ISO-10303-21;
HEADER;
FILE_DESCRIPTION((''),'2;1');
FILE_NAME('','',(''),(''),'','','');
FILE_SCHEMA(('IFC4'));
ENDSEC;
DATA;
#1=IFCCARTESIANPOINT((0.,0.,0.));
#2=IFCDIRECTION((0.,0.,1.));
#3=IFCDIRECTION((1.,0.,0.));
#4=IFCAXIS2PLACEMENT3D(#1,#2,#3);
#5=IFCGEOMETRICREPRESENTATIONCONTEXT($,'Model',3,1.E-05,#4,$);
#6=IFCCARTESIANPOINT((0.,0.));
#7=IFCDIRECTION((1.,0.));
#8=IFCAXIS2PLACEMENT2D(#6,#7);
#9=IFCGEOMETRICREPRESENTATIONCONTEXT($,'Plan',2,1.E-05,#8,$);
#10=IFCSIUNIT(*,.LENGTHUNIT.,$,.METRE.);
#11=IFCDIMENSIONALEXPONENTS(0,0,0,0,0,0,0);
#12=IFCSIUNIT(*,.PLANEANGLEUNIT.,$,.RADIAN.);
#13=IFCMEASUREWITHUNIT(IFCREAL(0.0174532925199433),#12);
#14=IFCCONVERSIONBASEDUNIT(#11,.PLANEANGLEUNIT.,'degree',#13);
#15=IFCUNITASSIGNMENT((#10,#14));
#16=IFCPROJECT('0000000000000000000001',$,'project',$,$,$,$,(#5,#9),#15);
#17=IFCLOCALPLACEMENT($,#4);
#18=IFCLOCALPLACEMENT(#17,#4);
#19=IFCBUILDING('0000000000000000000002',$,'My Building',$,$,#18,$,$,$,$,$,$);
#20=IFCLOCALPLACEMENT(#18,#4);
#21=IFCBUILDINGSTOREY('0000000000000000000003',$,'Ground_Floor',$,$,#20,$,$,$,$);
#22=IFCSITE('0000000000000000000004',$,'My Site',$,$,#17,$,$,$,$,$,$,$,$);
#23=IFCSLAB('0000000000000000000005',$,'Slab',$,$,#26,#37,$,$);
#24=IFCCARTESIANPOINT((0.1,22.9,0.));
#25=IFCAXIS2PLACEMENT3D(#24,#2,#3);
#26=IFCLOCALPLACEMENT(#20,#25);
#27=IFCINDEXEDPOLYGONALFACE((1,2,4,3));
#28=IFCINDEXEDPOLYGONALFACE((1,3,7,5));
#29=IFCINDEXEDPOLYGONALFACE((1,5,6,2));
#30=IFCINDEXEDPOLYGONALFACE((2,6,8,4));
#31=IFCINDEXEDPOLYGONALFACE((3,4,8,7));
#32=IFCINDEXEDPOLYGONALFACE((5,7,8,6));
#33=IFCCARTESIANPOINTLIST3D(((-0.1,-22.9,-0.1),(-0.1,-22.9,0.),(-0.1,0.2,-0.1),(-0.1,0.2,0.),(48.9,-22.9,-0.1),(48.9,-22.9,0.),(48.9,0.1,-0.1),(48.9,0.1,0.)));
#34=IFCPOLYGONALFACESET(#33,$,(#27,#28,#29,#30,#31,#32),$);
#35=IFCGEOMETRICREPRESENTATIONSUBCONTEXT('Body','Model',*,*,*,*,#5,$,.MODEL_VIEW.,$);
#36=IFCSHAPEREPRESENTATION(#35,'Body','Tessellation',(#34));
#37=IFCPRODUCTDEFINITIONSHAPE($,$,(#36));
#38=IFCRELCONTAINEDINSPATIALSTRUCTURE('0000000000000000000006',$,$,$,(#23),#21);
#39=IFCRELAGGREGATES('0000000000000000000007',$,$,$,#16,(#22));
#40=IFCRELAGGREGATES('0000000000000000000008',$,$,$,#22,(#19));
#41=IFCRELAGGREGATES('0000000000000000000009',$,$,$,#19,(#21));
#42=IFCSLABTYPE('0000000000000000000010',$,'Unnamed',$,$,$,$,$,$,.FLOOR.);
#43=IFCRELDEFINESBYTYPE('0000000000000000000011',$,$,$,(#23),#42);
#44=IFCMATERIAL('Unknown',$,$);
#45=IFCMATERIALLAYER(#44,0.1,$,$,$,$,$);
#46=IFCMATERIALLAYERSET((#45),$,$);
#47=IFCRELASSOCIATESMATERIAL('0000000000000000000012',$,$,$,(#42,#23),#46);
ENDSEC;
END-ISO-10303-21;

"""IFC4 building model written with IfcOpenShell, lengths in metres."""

from ifc_helpers import new_model, entity, si_unit, converted_unit, frame, origin_with_axes, origin_2d_with_axis, place, context, subcontext, project, spatial, indexed_curve, outline, extrude, material, layer, layer_set, layer_usage, type_object, element, save


model = new_model("IFC4")

# Units and contexts
model_context = context("Model", 3, precision=1e-05, world=origin_with_axes())
plan_context = context("Plan", 2, precision=1e-05, world=origin_2d_with_axis())
body_context_1 = subcontext(model_context, "Body", "Model", "MODEL_VIEW")
ifc_project = project(units=[si_unit("LENGTHUNIT", "METRE"), converted_unit("PLANEANGLEUNIT", "degree", entity("IfcReal", 0.0174532925199433), si_unit("PLANEANGLEUNIT", "RADIAN"), dimensions=[0, 0, 0, 0, 0, 0, 0])], contexts=[model_context, plan_context])

# Site, building, storey
site_placement = place(None, origin_with_axes())
site = spatial("IfcSite", under=ifc_project, at=site_placement, Name="My Site")
building_placement = place(site_placement, origin_with_axes())
building = spatial("IfcBuilding", under=site, at=building_placement, Name="My Building")
storey_placement = place(building_placement, origin_with_axes())
storey = spatial("IfcBuildingStorey", under=building, at=storey_placement, Name="Ground_Floor")

# Slab
ifc_material = material(Name="Unknown")
ifc_layer_1 = layer(ifc_material, 0.1)
ifc_layer_set_1 = layer_set([ifc_layer_1])
ifc_layer_usage_1 = layer_usage(ifc_layer_set_1, "AXIS3", "POSITIVE", -0.1)
slab_type = type_object("IfcSlabType", Name="Unnamed", PredefinedType="FLOOR", material=ifc_layer_set_1)
slab_placement = place(storey_placement, frame((0.1, 22.9, 0.0), z_axis=(0.0, 0.0, 1.0), x_axis=(1.0, 0.0, 0.0)))
element("IfcSlab", 1, at=slab_placement, inside=storey, type_object=slab_type, material=ifc_layer_usage_1, Name="Slab", context=body_context_1, shape_type="SweptSolid", body=[
    extrude(outline(indexed_curve([(-0.1, -22.9), (48.9, -22.9), (48.9, 0.1), (-0.1, 0.2), (-0.1, -22.9)])), frame((0.0, 0.0, -0.1), z_axis=(0.0, 0.0, 1.0), x_axis=(1.0, 0.0, 0.0)), (0.0, 0.0, 1.0), 0.1),
])

save(model, "model.ifc")
